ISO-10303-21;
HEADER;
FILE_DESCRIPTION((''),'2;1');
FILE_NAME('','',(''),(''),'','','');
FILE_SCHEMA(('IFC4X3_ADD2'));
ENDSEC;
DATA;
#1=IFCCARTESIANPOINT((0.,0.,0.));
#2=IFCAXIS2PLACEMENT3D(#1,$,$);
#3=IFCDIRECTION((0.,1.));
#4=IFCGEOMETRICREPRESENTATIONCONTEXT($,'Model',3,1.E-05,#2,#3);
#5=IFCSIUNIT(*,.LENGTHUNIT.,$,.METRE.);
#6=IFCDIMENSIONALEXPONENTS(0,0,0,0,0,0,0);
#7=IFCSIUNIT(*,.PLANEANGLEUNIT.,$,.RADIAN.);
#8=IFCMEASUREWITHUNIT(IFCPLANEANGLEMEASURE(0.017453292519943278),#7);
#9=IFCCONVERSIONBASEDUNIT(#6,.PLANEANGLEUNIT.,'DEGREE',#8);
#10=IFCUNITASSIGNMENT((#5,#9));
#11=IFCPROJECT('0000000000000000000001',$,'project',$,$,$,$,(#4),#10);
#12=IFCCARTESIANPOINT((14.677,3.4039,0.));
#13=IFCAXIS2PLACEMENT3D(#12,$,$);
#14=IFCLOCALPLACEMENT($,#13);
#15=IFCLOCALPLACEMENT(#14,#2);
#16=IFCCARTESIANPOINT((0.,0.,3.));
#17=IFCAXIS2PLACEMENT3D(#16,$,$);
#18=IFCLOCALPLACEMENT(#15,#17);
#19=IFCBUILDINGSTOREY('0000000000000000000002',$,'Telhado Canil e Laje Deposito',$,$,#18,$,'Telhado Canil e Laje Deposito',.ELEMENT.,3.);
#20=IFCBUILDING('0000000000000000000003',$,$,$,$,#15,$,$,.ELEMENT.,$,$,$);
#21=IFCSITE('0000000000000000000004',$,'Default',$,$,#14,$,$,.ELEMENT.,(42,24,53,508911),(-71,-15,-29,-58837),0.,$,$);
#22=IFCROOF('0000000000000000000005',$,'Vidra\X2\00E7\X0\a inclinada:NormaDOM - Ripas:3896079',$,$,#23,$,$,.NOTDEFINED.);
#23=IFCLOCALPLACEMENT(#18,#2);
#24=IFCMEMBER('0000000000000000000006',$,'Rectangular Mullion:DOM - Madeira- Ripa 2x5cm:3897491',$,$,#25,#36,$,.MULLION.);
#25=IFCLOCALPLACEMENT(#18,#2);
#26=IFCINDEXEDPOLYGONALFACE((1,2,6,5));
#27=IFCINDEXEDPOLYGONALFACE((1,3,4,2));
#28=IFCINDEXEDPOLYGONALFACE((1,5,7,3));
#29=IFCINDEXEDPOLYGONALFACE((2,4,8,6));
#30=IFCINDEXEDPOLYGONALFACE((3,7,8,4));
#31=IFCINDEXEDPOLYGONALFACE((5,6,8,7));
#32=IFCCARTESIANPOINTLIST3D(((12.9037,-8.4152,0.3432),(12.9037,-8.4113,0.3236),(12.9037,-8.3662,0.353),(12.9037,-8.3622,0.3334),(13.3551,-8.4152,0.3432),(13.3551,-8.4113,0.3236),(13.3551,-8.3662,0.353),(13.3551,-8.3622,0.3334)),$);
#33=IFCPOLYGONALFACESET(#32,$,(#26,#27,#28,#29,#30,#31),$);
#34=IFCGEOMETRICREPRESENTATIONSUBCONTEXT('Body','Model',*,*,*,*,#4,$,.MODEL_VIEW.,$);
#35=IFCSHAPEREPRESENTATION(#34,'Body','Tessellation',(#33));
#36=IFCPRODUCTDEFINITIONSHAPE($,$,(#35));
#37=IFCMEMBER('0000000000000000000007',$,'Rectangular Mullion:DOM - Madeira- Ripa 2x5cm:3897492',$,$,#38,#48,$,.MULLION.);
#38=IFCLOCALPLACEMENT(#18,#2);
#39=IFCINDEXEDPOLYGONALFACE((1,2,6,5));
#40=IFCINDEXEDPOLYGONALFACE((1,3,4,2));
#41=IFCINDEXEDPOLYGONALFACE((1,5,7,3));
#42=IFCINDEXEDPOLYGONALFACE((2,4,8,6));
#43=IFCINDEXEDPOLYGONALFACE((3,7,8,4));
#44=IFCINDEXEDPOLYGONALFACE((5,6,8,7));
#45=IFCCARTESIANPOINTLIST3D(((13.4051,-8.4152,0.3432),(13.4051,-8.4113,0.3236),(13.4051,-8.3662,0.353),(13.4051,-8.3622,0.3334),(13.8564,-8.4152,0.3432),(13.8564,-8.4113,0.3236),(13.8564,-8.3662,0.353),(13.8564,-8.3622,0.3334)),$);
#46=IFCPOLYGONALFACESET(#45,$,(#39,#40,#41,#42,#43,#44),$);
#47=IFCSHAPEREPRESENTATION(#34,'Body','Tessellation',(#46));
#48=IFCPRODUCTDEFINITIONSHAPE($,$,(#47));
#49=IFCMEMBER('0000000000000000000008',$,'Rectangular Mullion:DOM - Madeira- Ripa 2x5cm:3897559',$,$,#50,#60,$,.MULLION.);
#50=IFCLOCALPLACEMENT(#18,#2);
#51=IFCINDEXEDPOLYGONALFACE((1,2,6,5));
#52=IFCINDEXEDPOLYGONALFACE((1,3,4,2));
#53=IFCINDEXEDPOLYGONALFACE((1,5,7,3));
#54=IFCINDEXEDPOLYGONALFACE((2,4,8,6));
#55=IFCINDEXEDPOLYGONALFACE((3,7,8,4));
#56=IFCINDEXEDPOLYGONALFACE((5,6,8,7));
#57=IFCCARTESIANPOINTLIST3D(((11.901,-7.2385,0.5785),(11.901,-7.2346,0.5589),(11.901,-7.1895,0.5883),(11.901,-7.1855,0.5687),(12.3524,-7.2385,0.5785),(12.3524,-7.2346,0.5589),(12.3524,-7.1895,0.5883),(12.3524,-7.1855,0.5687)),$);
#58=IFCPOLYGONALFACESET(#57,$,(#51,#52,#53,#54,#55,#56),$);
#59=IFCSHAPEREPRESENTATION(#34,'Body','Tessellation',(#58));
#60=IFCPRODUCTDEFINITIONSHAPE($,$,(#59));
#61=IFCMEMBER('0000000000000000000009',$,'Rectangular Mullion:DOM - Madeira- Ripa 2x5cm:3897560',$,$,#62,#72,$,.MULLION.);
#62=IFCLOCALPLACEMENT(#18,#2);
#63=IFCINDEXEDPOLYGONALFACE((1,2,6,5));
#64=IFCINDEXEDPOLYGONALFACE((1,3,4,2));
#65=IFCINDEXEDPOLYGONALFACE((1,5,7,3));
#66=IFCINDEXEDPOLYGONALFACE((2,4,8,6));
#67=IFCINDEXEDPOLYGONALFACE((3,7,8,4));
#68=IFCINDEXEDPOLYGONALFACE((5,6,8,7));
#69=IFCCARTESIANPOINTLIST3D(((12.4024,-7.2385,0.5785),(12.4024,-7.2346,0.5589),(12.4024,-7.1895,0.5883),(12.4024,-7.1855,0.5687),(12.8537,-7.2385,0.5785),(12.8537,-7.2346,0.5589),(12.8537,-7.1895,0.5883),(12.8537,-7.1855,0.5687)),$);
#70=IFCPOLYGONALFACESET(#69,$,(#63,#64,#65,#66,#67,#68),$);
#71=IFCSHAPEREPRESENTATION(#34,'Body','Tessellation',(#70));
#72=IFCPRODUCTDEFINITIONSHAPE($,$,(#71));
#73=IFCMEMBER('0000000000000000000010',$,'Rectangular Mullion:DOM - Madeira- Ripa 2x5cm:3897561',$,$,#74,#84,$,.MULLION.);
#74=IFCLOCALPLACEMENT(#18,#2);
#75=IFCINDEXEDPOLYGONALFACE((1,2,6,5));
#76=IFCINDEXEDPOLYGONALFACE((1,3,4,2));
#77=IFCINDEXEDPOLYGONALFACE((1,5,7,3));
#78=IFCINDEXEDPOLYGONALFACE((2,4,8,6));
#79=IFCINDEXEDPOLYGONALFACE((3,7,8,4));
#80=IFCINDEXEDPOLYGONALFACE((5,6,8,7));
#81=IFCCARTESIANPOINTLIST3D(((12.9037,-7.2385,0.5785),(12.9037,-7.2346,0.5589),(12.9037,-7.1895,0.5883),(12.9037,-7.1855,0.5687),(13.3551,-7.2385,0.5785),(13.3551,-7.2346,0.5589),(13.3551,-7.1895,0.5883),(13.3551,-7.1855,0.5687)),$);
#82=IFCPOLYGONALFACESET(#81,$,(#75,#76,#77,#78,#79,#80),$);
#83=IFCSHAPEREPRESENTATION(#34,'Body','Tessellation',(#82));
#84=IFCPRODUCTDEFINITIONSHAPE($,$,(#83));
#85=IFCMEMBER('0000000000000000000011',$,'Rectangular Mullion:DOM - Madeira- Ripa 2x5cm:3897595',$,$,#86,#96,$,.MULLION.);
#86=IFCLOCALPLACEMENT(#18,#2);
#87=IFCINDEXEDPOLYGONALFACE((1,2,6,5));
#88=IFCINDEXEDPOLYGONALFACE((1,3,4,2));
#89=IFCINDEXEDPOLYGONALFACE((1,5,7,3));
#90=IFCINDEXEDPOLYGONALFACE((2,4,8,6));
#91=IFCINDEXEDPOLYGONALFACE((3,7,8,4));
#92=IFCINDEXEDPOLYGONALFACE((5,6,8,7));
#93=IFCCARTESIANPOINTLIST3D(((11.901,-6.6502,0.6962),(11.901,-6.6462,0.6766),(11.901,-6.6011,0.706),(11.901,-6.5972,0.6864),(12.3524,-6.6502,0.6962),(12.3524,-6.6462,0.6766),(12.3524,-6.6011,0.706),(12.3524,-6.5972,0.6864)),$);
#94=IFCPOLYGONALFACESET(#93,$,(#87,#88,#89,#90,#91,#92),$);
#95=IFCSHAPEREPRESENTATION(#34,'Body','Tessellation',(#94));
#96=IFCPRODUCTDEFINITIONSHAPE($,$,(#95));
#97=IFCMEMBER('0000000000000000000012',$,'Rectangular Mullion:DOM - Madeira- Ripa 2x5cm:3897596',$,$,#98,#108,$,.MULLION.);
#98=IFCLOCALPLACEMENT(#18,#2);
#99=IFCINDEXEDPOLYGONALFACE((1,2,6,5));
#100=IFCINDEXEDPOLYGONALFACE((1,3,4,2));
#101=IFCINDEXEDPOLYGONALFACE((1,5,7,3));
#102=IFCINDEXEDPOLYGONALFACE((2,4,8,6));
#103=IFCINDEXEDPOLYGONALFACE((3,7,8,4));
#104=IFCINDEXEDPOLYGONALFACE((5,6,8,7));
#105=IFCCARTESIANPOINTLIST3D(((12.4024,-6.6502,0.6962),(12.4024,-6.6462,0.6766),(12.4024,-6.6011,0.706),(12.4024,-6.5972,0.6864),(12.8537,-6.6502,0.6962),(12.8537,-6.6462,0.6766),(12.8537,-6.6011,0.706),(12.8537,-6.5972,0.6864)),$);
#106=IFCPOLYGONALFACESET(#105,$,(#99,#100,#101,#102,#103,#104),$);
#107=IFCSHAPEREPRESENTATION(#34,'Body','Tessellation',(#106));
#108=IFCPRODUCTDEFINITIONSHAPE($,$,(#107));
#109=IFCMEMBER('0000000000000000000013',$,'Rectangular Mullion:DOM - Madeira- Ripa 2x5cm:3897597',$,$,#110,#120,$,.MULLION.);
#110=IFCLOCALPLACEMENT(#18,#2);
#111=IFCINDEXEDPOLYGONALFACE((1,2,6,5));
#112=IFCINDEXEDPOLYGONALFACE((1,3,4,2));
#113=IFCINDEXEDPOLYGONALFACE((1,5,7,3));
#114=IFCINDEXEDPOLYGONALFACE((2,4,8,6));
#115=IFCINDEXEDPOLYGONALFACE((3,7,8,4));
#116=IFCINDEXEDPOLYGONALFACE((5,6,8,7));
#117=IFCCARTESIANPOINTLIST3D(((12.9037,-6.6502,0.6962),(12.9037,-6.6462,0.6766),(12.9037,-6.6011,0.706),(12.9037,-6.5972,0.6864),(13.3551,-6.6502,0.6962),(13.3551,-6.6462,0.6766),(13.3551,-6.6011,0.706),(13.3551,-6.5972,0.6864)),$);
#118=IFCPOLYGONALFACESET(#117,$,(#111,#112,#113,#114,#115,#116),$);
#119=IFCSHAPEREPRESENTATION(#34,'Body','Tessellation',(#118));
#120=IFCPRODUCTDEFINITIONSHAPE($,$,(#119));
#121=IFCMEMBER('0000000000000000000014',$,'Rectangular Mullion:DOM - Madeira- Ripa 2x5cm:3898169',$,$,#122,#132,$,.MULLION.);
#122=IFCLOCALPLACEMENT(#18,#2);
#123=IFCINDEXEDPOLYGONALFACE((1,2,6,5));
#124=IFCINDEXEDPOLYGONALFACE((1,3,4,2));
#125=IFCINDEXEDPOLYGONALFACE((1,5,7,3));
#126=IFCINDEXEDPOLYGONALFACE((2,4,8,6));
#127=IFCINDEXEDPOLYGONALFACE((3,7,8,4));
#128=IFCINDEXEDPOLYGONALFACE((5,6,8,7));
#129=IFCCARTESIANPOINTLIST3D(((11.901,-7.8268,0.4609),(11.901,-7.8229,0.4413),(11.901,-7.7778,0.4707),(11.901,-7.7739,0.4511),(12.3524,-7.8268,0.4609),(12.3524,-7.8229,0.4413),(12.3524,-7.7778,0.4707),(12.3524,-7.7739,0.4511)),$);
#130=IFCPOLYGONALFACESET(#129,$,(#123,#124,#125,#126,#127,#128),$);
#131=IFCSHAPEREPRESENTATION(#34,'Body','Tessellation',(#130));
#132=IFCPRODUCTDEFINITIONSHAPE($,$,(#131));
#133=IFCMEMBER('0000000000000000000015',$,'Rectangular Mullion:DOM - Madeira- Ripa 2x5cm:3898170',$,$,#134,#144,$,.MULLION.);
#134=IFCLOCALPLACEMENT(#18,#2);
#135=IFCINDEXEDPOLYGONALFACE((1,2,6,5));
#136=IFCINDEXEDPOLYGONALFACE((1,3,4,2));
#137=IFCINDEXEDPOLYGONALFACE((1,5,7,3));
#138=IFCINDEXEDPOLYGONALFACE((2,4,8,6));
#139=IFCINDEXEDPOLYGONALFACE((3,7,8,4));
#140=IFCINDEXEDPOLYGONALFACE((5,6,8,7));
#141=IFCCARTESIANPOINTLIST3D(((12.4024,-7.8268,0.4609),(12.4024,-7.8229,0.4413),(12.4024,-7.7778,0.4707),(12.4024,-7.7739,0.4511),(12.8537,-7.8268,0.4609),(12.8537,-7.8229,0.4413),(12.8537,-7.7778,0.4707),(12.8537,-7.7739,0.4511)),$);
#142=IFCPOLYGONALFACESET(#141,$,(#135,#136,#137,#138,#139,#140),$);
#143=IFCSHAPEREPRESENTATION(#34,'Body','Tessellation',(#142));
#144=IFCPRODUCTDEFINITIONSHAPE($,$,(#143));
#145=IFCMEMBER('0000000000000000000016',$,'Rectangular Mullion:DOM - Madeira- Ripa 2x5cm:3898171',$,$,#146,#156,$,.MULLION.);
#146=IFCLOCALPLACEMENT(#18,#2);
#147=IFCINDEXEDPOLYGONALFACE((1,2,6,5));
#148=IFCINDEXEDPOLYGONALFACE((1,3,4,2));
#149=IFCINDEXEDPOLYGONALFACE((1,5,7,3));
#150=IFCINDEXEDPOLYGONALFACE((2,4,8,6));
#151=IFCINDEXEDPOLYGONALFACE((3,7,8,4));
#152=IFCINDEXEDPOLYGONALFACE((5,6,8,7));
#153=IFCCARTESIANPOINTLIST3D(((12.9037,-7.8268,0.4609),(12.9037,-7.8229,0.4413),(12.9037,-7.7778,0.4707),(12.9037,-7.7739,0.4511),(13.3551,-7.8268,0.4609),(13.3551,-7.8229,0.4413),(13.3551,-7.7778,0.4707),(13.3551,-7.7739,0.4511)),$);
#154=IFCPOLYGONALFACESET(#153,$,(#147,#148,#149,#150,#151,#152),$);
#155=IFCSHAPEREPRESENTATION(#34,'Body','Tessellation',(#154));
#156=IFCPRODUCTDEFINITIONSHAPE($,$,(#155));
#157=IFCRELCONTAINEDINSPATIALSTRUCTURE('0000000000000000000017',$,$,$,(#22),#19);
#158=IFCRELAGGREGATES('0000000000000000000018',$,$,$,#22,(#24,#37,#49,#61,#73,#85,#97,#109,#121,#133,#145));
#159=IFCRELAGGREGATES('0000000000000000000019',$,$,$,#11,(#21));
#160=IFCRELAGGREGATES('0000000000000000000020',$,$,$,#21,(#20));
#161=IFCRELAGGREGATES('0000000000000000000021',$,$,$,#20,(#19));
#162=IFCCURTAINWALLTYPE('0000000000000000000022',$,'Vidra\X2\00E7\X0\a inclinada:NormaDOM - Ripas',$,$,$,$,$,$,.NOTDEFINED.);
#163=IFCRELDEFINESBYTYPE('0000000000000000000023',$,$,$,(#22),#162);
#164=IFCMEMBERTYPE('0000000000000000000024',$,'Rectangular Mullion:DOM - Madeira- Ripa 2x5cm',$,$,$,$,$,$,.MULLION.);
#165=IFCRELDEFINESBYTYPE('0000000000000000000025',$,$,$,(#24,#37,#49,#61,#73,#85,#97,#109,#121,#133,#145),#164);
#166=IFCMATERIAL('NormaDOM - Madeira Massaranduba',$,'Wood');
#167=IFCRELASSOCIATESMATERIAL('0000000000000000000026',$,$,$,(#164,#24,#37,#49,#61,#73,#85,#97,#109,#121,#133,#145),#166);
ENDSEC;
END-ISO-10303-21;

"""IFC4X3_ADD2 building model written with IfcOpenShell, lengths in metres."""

from ifc_helpers import new_model, entity, si_unit, converted_unit, direction, frame, origin, origin_2d_with_axis, place, context, subcontext, project, spatial, rectangle, extrude, source, transform, mapped, material, material_profile, profile_set, profile_usage, type_object, type_shapes, element, aggregate, save


model = new_model("IFC4X3_ADD2")

# Units and contexts
model_context = context("Model", 3, precision=1e-05, world=origin(), true_north=direction((0.0, 1.0)))
body_context = subcontext(model_context, "Body", "Model", "MODEL_VIEW")
ifc_project = project(units=[si_unit("LENGTHUNIT", "METRE"), converted_unit("PLANEANGLEUNIT", "DEGREE", entity("IfcPlaneAngleMeasure", 0.017453292519943278), si_unit("PLANEANGLEUNIT", "RADIAN"), dimensions=[0, 0, 0, 0, 0, 0, 0])], contexts=[model_context])

# Site, building, storey
site_placement = place(None, frame((14.677, 3.4039, 0.0)))
site = spatial("IfcSite", under=ifc_project, at=site_placement, Name="Default", CompositionType="ELEMENT", RefLatitude=(42, 24, 53, 508911), RefLongitude=(-71, -15, -29, -58837), RefElevation=0.0)
building_placement = place(site_placement, origin())
building = spatial("IfcBuilding", under=site, at=building_placement, CompositionType="ELEMENT")
storey_placement = place(building_placement, frame((0.0, 0.0, 3.0)))
storey = spatial("IfcBuildingStorey", under=building, at=storey_placement, Name="Telhado Canil e Laje Deposito", LongName="Telhado Canil e Laje Deposito", CompositionType="ELEMENT", Elevation=3.0)

# Roof, members
ifc_material = material(Name="NormaDOM - Madeira Massaranduba", Category="Wood")
ifc_material_profile_1 = material_profile(ifc_material, rectangle(XDim=0.05, YDim=0.02, at=origin_2d_with_axis()), Name="DOM - Madeira- Ripa 2x5cm")
ifc_profile_set_1 = profile_set([ifc_material_profile_1], Name="DOM - Madeira- Ripa 2x5cm")
ifc_profile_usage_1 = profile_usage(ifc_profile_set_1)
curtain_wall_type_1 = type_object("IfcCurtainWallType", Name="Vidraça inclinada:NormaDOM - Ripas", PredefinedType="NOTDEFINED")
roof_1_placement = place(storey_placement, frame((0.0, 0.0, -3.0)))
roof_1 = element("IfcRoof", 1, at=roof_1_placement, inside=storey, type_object=curtain_wall_type_1, Name="Vidraça inclinada:NormaDOM - Ripas:3896079", PredefinedType="NOTDEFINED")
member_type_1 = type_object("IfcMemberType", Name="Rectangular Mullion:DOM - Madeira- Ripa 2x5cm", PredefinedType="MULLION", material=ifc_profile_set_1)
shared_shape_1 = source(origin(), body_context, "Body", "SweptSolid", [
    extrude(rectangle(XDim=0.05, YDim=0.02, at=origin_2d_with_axis()), frame((0.025, 0.01, -0.4514), z_axis=(0.0, 0.0, 1.0), x_axis=(-1.0, 0.0, 0.0)), (0.0, 0.0, 1.0), 0.4514),
])
type_shapes(member_type_1, [shared_shape_1])
member_1_placement = place(roof_1_placement, frame((12.9037, -8.4152, 3.3432), z_axis=(-1.0, 0.0, 0.0), x_axis=(0.0, 0.980581, 0.196116)))
member_1 = element("IfcMember", 2, at=member_1_placement, type_object=member_type_1, material=ifc_profile_usage_1, Name="Rectangular Mullion:DOM - Madeira- Ripa 2x5cm:3897491", PredefinedType="MULLION", context=body_context, shape_type="MappedRepresentation", body=[
    mapped(shared_shape_1, transform((0.0, 0.0, 0.0), scale=1.0)),
])
member_2_placement = place(roof_1_placement, frame((13.4051, -8.4152, 3.3432), z_axis=(-1.0, 0.0, 0.0), x_axis=(0.0, 0.980581, 0.196116)))
member_2 = element("IfcMember", 3, at=member_2_placement, type_object=member_type_1, material=ifc_profile_usage_1, Name="Rectangular Mullion:DOM - Madeira- Ripa 2x5cm:3897492", PredefinedType="MULLION", context=body_context, shape_type="MappedRepresentation", body=[
    mapped(shared_shape_1, transform((0.0, 0.0, 0.0), scale=1.0)),
])
member_3_placement = place(roof_1_placement, frame((11.901, -7.2385, 3.5785), z_axis=(-1.0, 0.0, 0.0), x_axis=(0.0, 0.980581, 0.196116)))
member_3 = element("IfcMember", 4, at=member_3_placement, type_object=member_type_1, material=ifc_profile_usage_1, Name="Rectangular Mullion:DOM - Madeira- Ripa 2x5cm:3897559", PredefinedType="MULLION", context=body_context, shape_type="MappedRepresentation", body=[
    mapped(shared_shape_1, transform((0.0, 0.0, 0.0), scale=1.0)),
])
member_4_placement = place(roof_1_placement, frame((12.4024, -7.2385, 3.5785), z_axis=(-1.0, 0.0, 0.0), x_axis=(0.0, 0.980581, 0.196116)))
member_4 = element("IfcMember", 5, at=member_4_placement, type_object=member_type_1, material=ifc_profile_usage_1, Name="Rectangular Mullion:DOM - Madeira- Ripa 2x5cm:3897560", PredefinedType="MULLION", context=body_context, shape_type="MappedRepresentation", body=[
    mapped(shared_shape_1, transform((0.0, 0.0, 0.0), scale=1.0)),
])
member_5_placement = place(roof_1_placement, frame((12.9037, -7.2385, 3.5785), z_axis=(-1.0, 0.0, 0.0), x_axis=(0.0, 0.980581, 0.196116)))
member_5 = element("IfcMember", 6, at=member_5_placement, type_object=member_type_1, material=ifc_profile_usage_1, Name="Rectangular Mullion:DOM - Madeira- Ripa 2x5cm:3897561", PredefinedType="MULLION", context=body_context, shape_type="MappedRepresentation", body=[
    mapped(shared_shape_1, transform((0.0, 0.0, 0.0), scale=1.0)),
])
member_6_placement = place(roof_1_placement, frame((11.901, -6.6502, 3.6962), z_axis=(-1.0, 0.0, 0.0), x_axis=(0.0, 0.980581, 0.196116)))
member_6 = element("IfcMember", 7, at=member_6_placement, type_object=member_type_1, material=ifc_profile_usage_1, Name="Rectangular Mullion:DOM - Madeira- Ripa 2x5cm:3897595", PredefinedType="MULLION", context=body_context, shape_type="MappedRepresentation", body=[
    mapped(shared_shape_1, transform((0.0, 0.0, 0.0), scale=1.0)),
])
member_7_placement = place(roof_1_placement, frame((12.4024, -6.6502, 3.6962), z_axis=(-1.0, 0.0, 0.0), x_axis=(0.0, 0.980581, 0.196116)))
member_7 = element("IfcMember", 8, at=member_7_placement, type_object=member_type_1, material=ifc_profile_usage_1, Name="Rectangular Mullion:DOM - Madeira- Ripa 2x5cm:3897596", PredefinedType="MULLION", context=body_context, shape_type="MappedRepresentation", body=[
    mapped(shared_shape_1, transform((0.0, 0.0, 0.0), scale=1.0)),
])
member_8_placement = place(roof_1_placement, frame((12.9037, -6.6502, 3.6962), z_axis=(-1.0, 0.0, 0.0), x_axis=(0.0, 0.980581, 0.196116)))
member_8 = element("IfcMember", 9, at=member_8_placement, type_object=member_type_1, material=ifc_profile_usage_1, Name="Rectangular Mullion:DOM - Madeira- Ripa 2x5cm:3897597", PredefinedType="MULLION", context=body_context, shape_type="MappedRepresentation", body=[
    mapped(shared_shape_1, transform((0.0, 0.0, 0.0), scale=1.0)),
])
member_9_placement = place(roof_1_placement, frame((11.901, -7.8268, 3.4609), z_axis=(-1.0, 0.0, 0.0), x_axis=(0.0, 0.980581, 0.196116)))
member_9 = element("IfcMember", 10, at=member_9_placement, type_object=member_type_1, material=ifc_profile_usage_1, Name="Rectangular Mullion:DOM - Madeira- Ripa 2x5cm:3898169", PredefinedType="MULLION", context=body_context, shape_type="MappedRepresentation", body=[
    mapped(shared_shape_1, transform((0.0, 0.0, 0.0), scale=1.0)),
])
member_10_placement = place(roof_1_placement, frame((12.4024, -7.8268, 3.4609), z_axis=(-1.0, 0.0, 0.0), x_axis=(0.0, 0.980581, 0.196116)))
member_10 = element("IfcMember", 11, at=member_10_placement, type_object=member_type_1, material=ifc_profile_usage_1, Name="Rectangular Mullion:DOM - Madeira- Ripa 2x5cm:3898170", PredefinedType="MULLION", context=body_context, shape_type="MappedRepresentation", body=[
    mapped(shared_shape_1, transform((0.0, 0.0, 0.0), scale=1.0)),
])
member_11_placement = place(roof_1_placement, frame((12.9037, -7.8268, 3.4609), z_axis=(-1.0, 0.0, 0.0), x_axis=(0.0, 0.980581, 0.196116)))
member_11 = element("IfcMember", 12, at=member_11_placement, type_object=member_type_1, material=ifc_profile_usage_1, Name="Rectangular Mullion:DOM - Madeira- Ripa 2x5cm:3898171", PredefinedType="MULLION", context=body_context, shape_type="MappedRepresentation", body=[
    mapped(shared_shape_1, transform((0.0, 0.0, 0.0), scale=1.0)),
])
aggregate(roof_1, [member_1, member_2, member_3, member_4, member_5, member_6, member_7, member_8, member_9, member_10, member_11])

save(model, "model.ifc")
